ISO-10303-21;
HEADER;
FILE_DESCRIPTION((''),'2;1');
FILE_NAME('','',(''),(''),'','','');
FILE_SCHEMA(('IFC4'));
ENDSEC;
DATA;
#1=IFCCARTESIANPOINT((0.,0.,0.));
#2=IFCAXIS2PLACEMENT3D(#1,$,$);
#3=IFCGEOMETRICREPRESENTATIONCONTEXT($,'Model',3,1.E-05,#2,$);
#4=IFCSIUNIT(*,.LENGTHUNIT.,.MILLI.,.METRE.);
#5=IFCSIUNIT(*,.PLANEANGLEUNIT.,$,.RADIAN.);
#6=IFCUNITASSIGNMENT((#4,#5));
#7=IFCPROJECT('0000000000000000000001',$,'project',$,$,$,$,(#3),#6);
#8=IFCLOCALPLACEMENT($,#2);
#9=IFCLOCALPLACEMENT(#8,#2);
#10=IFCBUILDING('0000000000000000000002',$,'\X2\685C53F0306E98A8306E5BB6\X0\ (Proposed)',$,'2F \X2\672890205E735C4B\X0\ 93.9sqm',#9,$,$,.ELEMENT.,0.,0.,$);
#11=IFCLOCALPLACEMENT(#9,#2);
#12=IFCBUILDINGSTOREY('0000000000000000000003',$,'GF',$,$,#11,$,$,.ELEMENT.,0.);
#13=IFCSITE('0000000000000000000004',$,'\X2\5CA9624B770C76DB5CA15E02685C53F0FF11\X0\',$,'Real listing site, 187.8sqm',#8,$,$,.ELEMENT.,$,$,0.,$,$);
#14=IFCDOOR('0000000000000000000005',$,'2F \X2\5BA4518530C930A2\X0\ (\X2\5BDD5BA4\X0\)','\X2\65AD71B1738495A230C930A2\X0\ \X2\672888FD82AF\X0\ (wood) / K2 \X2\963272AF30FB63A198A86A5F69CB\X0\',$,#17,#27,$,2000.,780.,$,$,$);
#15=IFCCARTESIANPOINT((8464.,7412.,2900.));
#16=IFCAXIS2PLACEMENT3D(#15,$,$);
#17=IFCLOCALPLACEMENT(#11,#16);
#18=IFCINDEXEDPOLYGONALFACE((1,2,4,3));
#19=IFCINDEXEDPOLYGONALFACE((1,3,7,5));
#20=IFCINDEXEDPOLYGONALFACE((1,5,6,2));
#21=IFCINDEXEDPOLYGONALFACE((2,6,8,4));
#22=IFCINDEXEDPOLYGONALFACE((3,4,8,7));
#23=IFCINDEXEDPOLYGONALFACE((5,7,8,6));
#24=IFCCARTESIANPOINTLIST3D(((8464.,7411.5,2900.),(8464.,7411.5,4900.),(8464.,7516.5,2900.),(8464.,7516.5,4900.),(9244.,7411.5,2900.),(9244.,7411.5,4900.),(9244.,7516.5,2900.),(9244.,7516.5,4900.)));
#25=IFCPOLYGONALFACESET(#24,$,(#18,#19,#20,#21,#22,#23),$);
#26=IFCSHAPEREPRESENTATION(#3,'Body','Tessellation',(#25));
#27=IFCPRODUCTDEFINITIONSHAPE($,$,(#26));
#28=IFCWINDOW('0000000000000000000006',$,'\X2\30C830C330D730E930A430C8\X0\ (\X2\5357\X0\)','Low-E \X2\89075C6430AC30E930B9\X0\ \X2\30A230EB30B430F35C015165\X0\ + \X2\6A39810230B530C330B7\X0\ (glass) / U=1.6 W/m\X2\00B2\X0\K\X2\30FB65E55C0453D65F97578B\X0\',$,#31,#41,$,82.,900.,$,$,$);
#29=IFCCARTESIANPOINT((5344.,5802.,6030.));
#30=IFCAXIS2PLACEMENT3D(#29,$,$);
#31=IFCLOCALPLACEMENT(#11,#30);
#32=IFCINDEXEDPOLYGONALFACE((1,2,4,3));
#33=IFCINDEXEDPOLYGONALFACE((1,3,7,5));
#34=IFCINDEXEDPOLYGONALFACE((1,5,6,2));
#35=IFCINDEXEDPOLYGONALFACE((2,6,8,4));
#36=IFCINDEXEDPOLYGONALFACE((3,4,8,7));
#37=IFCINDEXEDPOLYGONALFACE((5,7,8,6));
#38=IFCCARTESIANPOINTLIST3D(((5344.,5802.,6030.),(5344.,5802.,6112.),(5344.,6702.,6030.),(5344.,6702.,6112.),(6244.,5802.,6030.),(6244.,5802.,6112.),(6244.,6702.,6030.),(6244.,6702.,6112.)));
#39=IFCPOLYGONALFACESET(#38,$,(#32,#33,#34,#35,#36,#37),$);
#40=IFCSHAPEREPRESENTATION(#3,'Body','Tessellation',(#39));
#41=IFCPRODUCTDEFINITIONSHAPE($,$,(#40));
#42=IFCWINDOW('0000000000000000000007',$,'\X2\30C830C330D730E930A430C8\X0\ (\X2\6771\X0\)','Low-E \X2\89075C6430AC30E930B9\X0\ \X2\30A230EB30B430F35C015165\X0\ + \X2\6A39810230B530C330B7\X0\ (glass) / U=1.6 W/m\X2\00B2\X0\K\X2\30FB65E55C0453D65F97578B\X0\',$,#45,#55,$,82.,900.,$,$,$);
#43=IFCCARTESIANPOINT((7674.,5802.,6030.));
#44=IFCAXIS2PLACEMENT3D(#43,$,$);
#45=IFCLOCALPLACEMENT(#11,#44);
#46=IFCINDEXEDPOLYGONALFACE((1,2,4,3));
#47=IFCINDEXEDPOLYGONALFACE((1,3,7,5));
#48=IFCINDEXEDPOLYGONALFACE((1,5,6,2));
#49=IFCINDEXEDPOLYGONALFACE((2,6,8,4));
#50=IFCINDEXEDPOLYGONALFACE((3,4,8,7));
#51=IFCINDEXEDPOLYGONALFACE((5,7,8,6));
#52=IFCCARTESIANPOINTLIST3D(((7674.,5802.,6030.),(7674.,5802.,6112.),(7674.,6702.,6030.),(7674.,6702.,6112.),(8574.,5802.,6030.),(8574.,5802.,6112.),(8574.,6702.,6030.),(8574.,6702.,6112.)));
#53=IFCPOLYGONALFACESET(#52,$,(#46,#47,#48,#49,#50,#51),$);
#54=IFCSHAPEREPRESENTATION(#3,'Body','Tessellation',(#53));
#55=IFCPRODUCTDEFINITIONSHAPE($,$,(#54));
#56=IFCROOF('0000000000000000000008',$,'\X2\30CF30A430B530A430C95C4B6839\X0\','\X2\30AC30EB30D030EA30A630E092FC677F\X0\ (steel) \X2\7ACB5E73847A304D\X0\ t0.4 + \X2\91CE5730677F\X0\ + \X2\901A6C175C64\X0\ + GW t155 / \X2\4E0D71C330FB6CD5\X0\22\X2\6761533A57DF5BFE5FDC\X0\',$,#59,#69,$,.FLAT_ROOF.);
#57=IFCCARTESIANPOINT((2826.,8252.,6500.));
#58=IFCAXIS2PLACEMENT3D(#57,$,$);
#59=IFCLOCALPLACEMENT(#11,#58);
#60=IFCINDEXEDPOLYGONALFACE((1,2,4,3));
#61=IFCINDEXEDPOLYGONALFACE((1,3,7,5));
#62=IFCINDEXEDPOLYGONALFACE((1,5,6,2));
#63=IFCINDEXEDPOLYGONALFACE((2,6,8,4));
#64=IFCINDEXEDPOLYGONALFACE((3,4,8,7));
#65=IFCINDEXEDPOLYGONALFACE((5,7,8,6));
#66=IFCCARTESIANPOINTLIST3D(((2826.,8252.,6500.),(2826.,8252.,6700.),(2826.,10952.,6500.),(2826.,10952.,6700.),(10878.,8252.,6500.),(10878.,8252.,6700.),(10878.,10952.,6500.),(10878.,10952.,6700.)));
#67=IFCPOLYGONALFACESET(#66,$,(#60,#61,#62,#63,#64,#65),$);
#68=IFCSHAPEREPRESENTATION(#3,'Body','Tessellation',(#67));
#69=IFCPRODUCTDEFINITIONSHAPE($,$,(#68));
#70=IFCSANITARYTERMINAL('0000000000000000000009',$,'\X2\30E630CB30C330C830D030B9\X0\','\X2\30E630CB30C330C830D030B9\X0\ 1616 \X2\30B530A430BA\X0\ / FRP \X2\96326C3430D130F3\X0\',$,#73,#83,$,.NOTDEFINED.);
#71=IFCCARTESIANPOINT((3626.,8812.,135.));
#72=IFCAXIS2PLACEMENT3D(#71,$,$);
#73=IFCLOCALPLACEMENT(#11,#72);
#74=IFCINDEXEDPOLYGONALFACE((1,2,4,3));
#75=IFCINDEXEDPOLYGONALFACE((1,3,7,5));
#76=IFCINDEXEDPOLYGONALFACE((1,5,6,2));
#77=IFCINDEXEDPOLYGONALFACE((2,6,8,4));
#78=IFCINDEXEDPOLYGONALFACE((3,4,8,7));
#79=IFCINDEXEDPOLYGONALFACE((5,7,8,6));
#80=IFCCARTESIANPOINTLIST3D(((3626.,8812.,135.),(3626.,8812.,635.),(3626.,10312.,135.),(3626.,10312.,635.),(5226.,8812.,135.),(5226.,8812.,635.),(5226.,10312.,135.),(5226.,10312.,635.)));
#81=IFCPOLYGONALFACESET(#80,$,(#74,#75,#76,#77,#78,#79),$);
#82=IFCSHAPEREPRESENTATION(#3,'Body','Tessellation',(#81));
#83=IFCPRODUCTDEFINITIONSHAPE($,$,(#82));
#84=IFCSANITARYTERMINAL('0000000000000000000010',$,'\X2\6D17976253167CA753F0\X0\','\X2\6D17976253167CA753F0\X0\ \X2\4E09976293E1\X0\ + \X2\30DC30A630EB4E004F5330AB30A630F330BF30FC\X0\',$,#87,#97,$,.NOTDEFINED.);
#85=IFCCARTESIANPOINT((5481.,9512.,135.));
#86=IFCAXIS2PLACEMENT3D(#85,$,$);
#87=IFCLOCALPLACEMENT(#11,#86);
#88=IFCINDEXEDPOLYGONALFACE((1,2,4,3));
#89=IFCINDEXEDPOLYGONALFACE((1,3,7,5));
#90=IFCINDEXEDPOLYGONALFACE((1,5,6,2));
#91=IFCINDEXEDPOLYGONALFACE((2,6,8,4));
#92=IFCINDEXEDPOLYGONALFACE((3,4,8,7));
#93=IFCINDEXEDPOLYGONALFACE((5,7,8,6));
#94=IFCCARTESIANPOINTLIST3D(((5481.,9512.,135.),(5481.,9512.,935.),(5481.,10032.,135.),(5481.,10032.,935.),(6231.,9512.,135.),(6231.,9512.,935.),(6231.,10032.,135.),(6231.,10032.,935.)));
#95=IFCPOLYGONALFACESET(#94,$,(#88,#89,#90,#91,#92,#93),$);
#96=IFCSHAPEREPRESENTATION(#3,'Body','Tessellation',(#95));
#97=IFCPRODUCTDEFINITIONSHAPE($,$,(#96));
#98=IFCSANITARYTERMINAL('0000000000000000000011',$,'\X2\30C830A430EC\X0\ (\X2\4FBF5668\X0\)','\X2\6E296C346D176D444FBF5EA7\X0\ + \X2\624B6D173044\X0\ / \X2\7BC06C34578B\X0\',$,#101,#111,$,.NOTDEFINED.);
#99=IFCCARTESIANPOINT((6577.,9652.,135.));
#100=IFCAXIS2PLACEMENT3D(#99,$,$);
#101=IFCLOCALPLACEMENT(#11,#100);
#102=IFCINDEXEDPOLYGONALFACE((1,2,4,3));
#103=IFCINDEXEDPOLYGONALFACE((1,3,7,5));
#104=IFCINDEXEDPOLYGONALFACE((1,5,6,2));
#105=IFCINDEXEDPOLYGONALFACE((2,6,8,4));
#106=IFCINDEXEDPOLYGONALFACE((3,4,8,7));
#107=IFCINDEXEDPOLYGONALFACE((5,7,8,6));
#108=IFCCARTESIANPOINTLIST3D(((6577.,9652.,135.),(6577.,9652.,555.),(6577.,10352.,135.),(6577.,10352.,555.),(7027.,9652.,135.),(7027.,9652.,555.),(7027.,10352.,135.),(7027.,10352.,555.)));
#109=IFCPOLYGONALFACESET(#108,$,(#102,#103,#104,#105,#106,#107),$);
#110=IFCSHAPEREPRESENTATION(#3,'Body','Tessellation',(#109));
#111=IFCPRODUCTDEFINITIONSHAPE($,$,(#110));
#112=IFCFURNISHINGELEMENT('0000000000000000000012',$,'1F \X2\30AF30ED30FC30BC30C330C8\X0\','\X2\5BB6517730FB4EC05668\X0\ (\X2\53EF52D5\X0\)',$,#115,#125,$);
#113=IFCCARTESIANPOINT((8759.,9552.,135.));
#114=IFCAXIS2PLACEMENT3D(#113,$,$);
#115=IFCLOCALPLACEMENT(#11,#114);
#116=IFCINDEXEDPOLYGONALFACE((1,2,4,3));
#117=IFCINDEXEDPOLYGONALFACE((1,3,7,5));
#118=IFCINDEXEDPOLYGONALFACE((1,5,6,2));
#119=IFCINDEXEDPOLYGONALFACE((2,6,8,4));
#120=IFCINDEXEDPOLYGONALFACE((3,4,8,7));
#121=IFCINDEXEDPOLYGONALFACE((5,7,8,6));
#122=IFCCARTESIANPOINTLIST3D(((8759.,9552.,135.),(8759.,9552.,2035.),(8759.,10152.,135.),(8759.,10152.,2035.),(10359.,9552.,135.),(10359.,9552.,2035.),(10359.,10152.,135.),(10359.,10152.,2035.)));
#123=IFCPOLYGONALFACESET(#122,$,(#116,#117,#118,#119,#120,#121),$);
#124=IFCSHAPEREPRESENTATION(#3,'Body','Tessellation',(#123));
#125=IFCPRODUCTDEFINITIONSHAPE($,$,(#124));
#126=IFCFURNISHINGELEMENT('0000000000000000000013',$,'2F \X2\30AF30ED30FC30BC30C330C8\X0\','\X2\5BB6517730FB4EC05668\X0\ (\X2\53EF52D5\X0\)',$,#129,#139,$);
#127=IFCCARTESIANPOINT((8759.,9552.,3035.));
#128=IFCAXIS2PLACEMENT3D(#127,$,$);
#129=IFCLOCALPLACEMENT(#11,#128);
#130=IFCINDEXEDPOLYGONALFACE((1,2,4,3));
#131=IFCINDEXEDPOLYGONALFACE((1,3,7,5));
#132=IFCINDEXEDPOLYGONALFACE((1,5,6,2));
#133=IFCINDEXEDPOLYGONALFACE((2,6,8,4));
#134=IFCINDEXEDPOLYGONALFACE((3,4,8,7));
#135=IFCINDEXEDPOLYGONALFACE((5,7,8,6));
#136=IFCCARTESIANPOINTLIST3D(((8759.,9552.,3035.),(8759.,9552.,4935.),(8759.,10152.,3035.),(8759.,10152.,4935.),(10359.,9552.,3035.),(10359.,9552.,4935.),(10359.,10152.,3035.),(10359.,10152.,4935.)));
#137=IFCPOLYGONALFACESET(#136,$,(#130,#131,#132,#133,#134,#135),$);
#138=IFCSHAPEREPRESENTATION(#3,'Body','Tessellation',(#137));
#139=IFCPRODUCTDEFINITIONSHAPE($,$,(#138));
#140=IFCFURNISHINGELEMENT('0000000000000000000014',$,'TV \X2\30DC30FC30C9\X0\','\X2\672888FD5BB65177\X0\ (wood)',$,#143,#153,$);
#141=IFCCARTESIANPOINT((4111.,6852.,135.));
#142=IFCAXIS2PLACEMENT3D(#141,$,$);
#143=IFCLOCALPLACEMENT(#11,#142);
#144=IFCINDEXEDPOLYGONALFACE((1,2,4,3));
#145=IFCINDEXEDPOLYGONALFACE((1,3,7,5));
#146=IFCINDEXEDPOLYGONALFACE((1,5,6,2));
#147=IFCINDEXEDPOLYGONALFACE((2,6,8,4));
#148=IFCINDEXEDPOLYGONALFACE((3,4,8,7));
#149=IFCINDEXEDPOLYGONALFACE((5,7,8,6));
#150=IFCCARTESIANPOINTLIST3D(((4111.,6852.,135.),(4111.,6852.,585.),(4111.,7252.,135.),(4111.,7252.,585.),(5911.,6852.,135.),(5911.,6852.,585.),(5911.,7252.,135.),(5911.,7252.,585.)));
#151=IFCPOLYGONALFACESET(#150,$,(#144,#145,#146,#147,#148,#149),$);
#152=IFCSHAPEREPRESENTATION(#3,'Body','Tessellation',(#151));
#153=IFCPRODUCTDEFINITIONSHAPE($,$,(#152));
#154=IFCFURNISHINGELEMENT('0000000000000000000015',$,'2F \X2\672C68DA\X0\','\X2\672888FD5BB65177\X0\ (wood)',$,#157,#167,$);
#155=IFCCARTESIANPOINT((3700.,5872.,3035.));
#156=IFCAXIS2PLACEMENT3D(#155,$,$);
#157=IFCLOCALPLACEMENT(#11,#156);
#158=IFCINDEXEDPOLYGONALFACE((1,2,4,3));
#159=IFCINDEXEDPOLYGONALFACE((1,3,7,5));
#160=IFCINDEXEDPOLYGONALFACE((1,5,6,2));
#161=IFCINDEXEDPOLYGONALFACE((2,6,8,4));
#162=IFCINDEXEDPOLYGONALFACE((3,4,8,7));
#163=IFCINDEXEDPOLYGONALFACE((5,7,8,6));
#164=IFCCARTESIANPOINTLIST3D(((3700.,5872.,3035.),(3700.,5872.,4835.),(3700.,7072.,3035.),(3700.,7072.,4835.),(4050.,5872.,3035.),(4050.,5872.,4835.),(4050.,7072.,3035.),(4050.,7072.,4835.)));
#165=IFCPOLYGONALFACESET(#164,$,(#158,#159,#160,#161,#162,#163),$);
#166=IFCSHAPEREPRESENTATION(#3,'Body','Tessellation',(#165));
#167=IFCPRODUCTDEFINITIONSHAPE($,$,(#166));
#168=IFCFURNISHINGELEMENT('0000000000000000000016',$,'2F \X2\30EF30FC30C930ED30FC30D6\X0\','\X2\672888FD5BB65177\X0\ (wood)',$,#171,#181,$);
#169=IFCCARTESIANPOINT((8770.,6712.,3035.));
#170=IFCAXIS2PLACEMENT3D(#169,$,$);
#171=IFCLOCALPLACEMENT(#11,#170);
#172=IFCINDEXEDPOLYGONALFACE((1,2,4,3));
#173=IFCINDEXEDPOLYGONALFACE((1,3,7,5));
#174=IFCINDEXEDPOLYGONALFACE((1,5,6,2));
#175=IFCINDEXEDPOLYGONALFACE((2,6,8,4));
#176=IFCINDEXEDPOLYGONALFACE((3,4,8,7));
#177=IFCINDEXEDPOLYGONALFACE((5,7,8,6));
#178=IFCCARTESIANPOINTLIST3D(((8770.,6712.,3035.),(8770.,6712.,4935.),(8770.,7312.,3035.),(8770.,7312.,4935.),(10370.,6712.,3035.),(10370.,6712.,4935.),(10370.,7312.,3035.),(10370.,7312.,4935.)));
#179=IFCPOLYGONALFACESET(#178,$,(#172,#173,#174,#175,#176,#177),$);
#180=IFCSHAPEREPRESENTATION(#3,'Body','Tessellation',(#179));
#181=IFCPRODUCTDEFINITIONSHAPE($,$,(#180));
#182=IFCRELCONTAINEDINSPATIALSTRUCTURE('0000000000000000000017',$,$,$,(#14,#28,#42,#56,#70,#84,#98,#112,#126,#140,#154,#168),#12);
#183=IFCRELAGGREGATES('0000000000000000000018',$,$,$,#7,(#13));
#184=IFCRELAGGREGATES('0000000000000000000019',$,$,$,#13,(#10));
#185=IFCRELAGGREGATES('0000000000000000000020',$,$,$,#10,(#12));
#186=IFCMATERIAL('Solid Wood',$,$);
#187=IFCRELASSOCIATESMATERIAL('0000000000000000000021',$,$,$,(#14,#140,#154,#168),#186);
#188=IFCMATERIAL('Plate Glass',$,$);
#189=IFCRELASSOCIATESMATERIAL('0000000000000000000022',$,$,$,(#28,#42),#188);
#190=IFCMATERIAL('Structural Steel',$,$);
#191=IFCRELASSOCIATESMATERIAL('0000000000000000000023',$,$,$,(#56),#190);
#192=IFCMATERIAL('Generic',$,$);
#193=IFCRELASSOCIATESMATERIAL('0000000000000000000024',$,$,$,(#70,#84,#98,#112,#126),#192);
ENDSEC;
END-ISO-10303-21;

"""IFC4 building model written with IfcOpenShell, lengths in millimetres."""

from ifc_helpers import new_model, si_unit, frame, frame_2d, origin, place, context, project, spatial, rectangle, extrude, material, element, save


model = new_model("IFC4")

# Units and contexts
model_context = context("Model", 3, precision=1e-05, world=origin())
ifc_project = project(units=[si_unit("LENGTHUNIT", "METRE", prefix="MILLI"), si_unit("PLANEANGLEUNIT", "RADIAN")], contexts=[model_context])

# Site, building, storey
site_placement = place(None, origin())
site = spatial("IfcSite", under=ifc_project, at=site_placement, Name="岩手県盛岡市桜台１", ObjectType="Real listing site, 187.8sqm", CompositionType="ELEMENT", RefElevation=0.0)
building_placement = place(site_placement, origin())
building = spatial("IfcBuilding", under=site, at=building_placement, Name="桜台の風の家 (Proposed)", ObjectType="2F 木造平屋 93.9sqm", CompositionType="ELEMENT", ElevationOfRefHeight=0.0, ElevationOfTerrain=0.0)
storey_placement = place(building_placement, origin())
storey = spatial("IfcBuildingStorey", under=building, at=storey_placement, Name="GF", CompositionType="ELEMENT", Elevation=0.0)

# Shared definitions
ifc_material_1 = material(Name="Solid Wood")
ifc_material_2 = material(Name="Plate Glass")

# Door
door_1_placement = place(storey_placement, frame((8464.0, 7412.0, 2900.0)))
element("IfcDoor", 1, at=door_1_placement, inside=storey, material=ifc_material_1, Name="2F 室内ドア (寝室)", Description="断熱玄関ドア 木製芯 (wood) / K2 防犯・採風機構", OverallHeight=2000.0, OverallWidth=780.0, context=model_context, shape_type="SweptSolid", body=[
    extrude(rectangle(XDim=780.0, YDim=105.0, at=frame_2d((390.0, 52.0))), frame((8464.0, 7412.0, 2900.0)), (0.0, 0.0, 1.0), 2000.0),
])

# Windows
window_1_placement = place(storey_placement, frame((5344.0, 5802.0, 6030.0)))
element("IfcWindow", 2, at=window_1_placement, inside=storey, material=ifc_material_2, Name="トップライト (南)", Description="Low-E 複層ガラス アルゴン封入 + 樹脂サッシ (glass) / U=1.6 W/m²K・日射取得型", OverallHeight=82.0, OverallWidth=900.0, context=model_context, shape_type="SweptSolid", body=[
    extrude(rectangle(XDim=900.0, YDim=900.0, at=frame_2d((450.0, 450.0))), frame((5344.0, 5802.0, 6030.0)), (0.0, 0.0, 1.0), 82.0),
])
window_2_placement = place(storey_placement, frame((7674.0, 5802.0, 6030.0)))
element("IfcWindow", 3, at=window_2_placement, inside=storey, material=ifc_material_2, Name="トップライト (東)", Description="Low-E 複層ガラス アルゴン封入 + 樹脂サッシ (glass) / U=1.6 W/m²K・日射取得型", OverallHeight=82.0, OverallWidth=900.0, context=model_context, shape_type="SweptSolid", body=[
    extrude(rectangle(XDim=900.0, YDim=900.0, at=frame_2d((450.0, 450.0))), frame((7674.0, 5802.0, 6030.0)), (0.0, 0.0, 1.0), 82.0),
])

# Roof
ifc_material_3 = material(Name="Structural Steel")
roof_placement = place(storey_placement, frame((2826.0, 8252.0, 6500.0)))
element("IfcRoof", 4, at=roof_placement, inside=storey, material=ifc_material_3, Name="ハイサイド屋根", Description="ガルバリウム鋼板 (steel) 立平葺き t0.4 + 野地板 + 通気層 + GW t155 / 不燃・法22条区域対応", PredefinedType="FLAT_ROOF", context=model_context, shape_type="SweptSolid", body=[
    extrude(rectangle(XDim=8052.0, YDim=2700.0, at=frame_2d((4026.0, 1350.0))), frame((2826.0, 8252.0, 6500.0)), (0.0, 0.0, 1.0), 200.0),
])

# Sanitary terminals
ifc_material_4 = material(Name="Generic")
sanitary_terminal_1_placement = place(storey_placement, frame((3626.0, 8812.0, 135.0)))
element("IfcSanitaryTerminal", 5, at=sanitary_terminal_1_placement, inside=storey, material=ifc_material_4, Name="ユニットバス", Description="ユニットバス 1616 サイズ / FRP 防水パン", PredefinedType="NOTDEFINED", context=model_context, shape_type="SweptSolid", body=[
    extrude(rectangle(XDim=1600.0, YDim=1500.0, at=frame_2d((800.0, 750.0))), frame((3626.0, 8812.0, 135.0)), (0.0, 0.0, 1.0), 500.0),
])
sanitary_terminal_2_placement = place(storey_placement, frame((5481.0, 9512.0, 135.0)))
element("IfcSanitaryTerminal", 6, at=sanitary_terminal_2_placement, inside=storey, material=ifc_material_4, Name="洗面化粧台", Description="洗面化粧台 三面鏡 + ボウル一体カウンター", PredefinedType="NOTDEFINED", context=model_context, shape_type="SweptSolid", body=[
    extrude(rectangle(XDim=750.0, YDim=520.0, at=frame_2d((375.0, 260.0))), frame((5481.0, 9512.0, 135.0)), (0.0, 0.0, 1.0), 800.0),
])
sanitary_terminal_3_placement = place(storey_placement, frame((6577.0, 9652.0, 135.0)))
element("IfcSanitaryTerminal", 7, at=sanitary_terminal_3_placement, inside=storey, material=ifc_material_4, Name="トイレ (便器)", Description="温水洗浄便座 + 手洗い / 節水型", PredefinedType="NOTDEFINED", context=model_context, shape_type="SweptSolid", body=[
    extrude(rectangle(XDim=450.0, YDim=700.0, at=frame_2d((225.0, 350.0))), frame((6577.0, 9652.0, 135.0)), (0.0, 0.0, 1.0), 420.0),
])

# Furnishing elements
furnishing_1_placement = place(storey_placement, frame((8759.0, 9552.0, 135.0)))
element("IfcFurnishingElement", 8, at=furnishing_1_placement, inside=storey, material=ifc_material_4, Name="1F クローゼット", Description="家具・什器 (可動)", context=model_context, shape_type="SweptSolid", body=[
    extrude(rectangle(XDim=1600.0, YDim=600.0, at=frame_2d((800.0, 300.0))), frame((8759.0, 9552.0, 135.0)), (0.0, 0.0, 1.0), 1900.0),
])
furnishing_2_placement = place(storey_placement, frame((8759.0, 9552.0, 3035.0)))
element("IfcFurnishingElement", 9, at=furnishing_2_placement, inside=storey, material=ifc_material_4, Name="2F クローゼット", Description="家具・什器 (可動)", context=model_context, shape_type="SweptSolid", body=[
    extrude(rectangle(XDim=1600.0, YDim=600.0, at=frame_2d((800.0, 300.0))), frame((8759.0, 9552.0, 3035.0)), (0.0, 0.0, 1.0), 1900.0),
])
furnishing_3_placement = place(storey_placement, frame((4111.0, 6852.0, 135.0)))
element("IfcFurnishingElement", 10, at=furnishing_3_placement, inside=storey, material=ifc_material_1, Name="TV ボード", Description="木製家具 (wood)", context=model_context, shape_type="SweptSolid", body=[
    extrude(rectangle(XDim=1800.0, YDim=400.0, at=frame_2d((900.0, 200.0))), frame((4111.0, 6852.0, 135.0)), (0.0, 0.0, 1.0), 450.0),
])
furnishing_4_placement = place(storey_placement, frame((3700.0, 5872.0, 3035.0)))
element("IfcFurnishingElement", 11, at=furnishing_4_placement, inside=storey, material=ifc_material_1, Name="2F 本棚", Description="木製家具 (wood)", context=model_context, shape_type="SweptSolid", body=[
    extrude(rectangle(XDim=350.0, YDim=1200.0, at=frame_2d((175.0, 600.0))), frame((3700.0, 5872.0, 3035.0)), (0.0, 0.0, 1.0), 1800.0),
])
furnishing_5_placement = place(storey_placement, frame((8770.0, 6712.0, 3035.0)))
element("IfcFurnishingElement", 12, at=furnishing_5_placement, inside=storey, material=ifc_material_1, Name="2F ワードローブ", Description="木製家具 (wood)", context=model_context, shape_type="SweptSolid", body=[
    extrude(rectangle(XDim=1600.0, YDim=600.0, at=frame_2d((800.0, 300.0))), frame((8770.0, 6712.0, 3035.0)), (0.0, 0.0, 1.0), 1900.0),
])

save(model, "model.ifc")
